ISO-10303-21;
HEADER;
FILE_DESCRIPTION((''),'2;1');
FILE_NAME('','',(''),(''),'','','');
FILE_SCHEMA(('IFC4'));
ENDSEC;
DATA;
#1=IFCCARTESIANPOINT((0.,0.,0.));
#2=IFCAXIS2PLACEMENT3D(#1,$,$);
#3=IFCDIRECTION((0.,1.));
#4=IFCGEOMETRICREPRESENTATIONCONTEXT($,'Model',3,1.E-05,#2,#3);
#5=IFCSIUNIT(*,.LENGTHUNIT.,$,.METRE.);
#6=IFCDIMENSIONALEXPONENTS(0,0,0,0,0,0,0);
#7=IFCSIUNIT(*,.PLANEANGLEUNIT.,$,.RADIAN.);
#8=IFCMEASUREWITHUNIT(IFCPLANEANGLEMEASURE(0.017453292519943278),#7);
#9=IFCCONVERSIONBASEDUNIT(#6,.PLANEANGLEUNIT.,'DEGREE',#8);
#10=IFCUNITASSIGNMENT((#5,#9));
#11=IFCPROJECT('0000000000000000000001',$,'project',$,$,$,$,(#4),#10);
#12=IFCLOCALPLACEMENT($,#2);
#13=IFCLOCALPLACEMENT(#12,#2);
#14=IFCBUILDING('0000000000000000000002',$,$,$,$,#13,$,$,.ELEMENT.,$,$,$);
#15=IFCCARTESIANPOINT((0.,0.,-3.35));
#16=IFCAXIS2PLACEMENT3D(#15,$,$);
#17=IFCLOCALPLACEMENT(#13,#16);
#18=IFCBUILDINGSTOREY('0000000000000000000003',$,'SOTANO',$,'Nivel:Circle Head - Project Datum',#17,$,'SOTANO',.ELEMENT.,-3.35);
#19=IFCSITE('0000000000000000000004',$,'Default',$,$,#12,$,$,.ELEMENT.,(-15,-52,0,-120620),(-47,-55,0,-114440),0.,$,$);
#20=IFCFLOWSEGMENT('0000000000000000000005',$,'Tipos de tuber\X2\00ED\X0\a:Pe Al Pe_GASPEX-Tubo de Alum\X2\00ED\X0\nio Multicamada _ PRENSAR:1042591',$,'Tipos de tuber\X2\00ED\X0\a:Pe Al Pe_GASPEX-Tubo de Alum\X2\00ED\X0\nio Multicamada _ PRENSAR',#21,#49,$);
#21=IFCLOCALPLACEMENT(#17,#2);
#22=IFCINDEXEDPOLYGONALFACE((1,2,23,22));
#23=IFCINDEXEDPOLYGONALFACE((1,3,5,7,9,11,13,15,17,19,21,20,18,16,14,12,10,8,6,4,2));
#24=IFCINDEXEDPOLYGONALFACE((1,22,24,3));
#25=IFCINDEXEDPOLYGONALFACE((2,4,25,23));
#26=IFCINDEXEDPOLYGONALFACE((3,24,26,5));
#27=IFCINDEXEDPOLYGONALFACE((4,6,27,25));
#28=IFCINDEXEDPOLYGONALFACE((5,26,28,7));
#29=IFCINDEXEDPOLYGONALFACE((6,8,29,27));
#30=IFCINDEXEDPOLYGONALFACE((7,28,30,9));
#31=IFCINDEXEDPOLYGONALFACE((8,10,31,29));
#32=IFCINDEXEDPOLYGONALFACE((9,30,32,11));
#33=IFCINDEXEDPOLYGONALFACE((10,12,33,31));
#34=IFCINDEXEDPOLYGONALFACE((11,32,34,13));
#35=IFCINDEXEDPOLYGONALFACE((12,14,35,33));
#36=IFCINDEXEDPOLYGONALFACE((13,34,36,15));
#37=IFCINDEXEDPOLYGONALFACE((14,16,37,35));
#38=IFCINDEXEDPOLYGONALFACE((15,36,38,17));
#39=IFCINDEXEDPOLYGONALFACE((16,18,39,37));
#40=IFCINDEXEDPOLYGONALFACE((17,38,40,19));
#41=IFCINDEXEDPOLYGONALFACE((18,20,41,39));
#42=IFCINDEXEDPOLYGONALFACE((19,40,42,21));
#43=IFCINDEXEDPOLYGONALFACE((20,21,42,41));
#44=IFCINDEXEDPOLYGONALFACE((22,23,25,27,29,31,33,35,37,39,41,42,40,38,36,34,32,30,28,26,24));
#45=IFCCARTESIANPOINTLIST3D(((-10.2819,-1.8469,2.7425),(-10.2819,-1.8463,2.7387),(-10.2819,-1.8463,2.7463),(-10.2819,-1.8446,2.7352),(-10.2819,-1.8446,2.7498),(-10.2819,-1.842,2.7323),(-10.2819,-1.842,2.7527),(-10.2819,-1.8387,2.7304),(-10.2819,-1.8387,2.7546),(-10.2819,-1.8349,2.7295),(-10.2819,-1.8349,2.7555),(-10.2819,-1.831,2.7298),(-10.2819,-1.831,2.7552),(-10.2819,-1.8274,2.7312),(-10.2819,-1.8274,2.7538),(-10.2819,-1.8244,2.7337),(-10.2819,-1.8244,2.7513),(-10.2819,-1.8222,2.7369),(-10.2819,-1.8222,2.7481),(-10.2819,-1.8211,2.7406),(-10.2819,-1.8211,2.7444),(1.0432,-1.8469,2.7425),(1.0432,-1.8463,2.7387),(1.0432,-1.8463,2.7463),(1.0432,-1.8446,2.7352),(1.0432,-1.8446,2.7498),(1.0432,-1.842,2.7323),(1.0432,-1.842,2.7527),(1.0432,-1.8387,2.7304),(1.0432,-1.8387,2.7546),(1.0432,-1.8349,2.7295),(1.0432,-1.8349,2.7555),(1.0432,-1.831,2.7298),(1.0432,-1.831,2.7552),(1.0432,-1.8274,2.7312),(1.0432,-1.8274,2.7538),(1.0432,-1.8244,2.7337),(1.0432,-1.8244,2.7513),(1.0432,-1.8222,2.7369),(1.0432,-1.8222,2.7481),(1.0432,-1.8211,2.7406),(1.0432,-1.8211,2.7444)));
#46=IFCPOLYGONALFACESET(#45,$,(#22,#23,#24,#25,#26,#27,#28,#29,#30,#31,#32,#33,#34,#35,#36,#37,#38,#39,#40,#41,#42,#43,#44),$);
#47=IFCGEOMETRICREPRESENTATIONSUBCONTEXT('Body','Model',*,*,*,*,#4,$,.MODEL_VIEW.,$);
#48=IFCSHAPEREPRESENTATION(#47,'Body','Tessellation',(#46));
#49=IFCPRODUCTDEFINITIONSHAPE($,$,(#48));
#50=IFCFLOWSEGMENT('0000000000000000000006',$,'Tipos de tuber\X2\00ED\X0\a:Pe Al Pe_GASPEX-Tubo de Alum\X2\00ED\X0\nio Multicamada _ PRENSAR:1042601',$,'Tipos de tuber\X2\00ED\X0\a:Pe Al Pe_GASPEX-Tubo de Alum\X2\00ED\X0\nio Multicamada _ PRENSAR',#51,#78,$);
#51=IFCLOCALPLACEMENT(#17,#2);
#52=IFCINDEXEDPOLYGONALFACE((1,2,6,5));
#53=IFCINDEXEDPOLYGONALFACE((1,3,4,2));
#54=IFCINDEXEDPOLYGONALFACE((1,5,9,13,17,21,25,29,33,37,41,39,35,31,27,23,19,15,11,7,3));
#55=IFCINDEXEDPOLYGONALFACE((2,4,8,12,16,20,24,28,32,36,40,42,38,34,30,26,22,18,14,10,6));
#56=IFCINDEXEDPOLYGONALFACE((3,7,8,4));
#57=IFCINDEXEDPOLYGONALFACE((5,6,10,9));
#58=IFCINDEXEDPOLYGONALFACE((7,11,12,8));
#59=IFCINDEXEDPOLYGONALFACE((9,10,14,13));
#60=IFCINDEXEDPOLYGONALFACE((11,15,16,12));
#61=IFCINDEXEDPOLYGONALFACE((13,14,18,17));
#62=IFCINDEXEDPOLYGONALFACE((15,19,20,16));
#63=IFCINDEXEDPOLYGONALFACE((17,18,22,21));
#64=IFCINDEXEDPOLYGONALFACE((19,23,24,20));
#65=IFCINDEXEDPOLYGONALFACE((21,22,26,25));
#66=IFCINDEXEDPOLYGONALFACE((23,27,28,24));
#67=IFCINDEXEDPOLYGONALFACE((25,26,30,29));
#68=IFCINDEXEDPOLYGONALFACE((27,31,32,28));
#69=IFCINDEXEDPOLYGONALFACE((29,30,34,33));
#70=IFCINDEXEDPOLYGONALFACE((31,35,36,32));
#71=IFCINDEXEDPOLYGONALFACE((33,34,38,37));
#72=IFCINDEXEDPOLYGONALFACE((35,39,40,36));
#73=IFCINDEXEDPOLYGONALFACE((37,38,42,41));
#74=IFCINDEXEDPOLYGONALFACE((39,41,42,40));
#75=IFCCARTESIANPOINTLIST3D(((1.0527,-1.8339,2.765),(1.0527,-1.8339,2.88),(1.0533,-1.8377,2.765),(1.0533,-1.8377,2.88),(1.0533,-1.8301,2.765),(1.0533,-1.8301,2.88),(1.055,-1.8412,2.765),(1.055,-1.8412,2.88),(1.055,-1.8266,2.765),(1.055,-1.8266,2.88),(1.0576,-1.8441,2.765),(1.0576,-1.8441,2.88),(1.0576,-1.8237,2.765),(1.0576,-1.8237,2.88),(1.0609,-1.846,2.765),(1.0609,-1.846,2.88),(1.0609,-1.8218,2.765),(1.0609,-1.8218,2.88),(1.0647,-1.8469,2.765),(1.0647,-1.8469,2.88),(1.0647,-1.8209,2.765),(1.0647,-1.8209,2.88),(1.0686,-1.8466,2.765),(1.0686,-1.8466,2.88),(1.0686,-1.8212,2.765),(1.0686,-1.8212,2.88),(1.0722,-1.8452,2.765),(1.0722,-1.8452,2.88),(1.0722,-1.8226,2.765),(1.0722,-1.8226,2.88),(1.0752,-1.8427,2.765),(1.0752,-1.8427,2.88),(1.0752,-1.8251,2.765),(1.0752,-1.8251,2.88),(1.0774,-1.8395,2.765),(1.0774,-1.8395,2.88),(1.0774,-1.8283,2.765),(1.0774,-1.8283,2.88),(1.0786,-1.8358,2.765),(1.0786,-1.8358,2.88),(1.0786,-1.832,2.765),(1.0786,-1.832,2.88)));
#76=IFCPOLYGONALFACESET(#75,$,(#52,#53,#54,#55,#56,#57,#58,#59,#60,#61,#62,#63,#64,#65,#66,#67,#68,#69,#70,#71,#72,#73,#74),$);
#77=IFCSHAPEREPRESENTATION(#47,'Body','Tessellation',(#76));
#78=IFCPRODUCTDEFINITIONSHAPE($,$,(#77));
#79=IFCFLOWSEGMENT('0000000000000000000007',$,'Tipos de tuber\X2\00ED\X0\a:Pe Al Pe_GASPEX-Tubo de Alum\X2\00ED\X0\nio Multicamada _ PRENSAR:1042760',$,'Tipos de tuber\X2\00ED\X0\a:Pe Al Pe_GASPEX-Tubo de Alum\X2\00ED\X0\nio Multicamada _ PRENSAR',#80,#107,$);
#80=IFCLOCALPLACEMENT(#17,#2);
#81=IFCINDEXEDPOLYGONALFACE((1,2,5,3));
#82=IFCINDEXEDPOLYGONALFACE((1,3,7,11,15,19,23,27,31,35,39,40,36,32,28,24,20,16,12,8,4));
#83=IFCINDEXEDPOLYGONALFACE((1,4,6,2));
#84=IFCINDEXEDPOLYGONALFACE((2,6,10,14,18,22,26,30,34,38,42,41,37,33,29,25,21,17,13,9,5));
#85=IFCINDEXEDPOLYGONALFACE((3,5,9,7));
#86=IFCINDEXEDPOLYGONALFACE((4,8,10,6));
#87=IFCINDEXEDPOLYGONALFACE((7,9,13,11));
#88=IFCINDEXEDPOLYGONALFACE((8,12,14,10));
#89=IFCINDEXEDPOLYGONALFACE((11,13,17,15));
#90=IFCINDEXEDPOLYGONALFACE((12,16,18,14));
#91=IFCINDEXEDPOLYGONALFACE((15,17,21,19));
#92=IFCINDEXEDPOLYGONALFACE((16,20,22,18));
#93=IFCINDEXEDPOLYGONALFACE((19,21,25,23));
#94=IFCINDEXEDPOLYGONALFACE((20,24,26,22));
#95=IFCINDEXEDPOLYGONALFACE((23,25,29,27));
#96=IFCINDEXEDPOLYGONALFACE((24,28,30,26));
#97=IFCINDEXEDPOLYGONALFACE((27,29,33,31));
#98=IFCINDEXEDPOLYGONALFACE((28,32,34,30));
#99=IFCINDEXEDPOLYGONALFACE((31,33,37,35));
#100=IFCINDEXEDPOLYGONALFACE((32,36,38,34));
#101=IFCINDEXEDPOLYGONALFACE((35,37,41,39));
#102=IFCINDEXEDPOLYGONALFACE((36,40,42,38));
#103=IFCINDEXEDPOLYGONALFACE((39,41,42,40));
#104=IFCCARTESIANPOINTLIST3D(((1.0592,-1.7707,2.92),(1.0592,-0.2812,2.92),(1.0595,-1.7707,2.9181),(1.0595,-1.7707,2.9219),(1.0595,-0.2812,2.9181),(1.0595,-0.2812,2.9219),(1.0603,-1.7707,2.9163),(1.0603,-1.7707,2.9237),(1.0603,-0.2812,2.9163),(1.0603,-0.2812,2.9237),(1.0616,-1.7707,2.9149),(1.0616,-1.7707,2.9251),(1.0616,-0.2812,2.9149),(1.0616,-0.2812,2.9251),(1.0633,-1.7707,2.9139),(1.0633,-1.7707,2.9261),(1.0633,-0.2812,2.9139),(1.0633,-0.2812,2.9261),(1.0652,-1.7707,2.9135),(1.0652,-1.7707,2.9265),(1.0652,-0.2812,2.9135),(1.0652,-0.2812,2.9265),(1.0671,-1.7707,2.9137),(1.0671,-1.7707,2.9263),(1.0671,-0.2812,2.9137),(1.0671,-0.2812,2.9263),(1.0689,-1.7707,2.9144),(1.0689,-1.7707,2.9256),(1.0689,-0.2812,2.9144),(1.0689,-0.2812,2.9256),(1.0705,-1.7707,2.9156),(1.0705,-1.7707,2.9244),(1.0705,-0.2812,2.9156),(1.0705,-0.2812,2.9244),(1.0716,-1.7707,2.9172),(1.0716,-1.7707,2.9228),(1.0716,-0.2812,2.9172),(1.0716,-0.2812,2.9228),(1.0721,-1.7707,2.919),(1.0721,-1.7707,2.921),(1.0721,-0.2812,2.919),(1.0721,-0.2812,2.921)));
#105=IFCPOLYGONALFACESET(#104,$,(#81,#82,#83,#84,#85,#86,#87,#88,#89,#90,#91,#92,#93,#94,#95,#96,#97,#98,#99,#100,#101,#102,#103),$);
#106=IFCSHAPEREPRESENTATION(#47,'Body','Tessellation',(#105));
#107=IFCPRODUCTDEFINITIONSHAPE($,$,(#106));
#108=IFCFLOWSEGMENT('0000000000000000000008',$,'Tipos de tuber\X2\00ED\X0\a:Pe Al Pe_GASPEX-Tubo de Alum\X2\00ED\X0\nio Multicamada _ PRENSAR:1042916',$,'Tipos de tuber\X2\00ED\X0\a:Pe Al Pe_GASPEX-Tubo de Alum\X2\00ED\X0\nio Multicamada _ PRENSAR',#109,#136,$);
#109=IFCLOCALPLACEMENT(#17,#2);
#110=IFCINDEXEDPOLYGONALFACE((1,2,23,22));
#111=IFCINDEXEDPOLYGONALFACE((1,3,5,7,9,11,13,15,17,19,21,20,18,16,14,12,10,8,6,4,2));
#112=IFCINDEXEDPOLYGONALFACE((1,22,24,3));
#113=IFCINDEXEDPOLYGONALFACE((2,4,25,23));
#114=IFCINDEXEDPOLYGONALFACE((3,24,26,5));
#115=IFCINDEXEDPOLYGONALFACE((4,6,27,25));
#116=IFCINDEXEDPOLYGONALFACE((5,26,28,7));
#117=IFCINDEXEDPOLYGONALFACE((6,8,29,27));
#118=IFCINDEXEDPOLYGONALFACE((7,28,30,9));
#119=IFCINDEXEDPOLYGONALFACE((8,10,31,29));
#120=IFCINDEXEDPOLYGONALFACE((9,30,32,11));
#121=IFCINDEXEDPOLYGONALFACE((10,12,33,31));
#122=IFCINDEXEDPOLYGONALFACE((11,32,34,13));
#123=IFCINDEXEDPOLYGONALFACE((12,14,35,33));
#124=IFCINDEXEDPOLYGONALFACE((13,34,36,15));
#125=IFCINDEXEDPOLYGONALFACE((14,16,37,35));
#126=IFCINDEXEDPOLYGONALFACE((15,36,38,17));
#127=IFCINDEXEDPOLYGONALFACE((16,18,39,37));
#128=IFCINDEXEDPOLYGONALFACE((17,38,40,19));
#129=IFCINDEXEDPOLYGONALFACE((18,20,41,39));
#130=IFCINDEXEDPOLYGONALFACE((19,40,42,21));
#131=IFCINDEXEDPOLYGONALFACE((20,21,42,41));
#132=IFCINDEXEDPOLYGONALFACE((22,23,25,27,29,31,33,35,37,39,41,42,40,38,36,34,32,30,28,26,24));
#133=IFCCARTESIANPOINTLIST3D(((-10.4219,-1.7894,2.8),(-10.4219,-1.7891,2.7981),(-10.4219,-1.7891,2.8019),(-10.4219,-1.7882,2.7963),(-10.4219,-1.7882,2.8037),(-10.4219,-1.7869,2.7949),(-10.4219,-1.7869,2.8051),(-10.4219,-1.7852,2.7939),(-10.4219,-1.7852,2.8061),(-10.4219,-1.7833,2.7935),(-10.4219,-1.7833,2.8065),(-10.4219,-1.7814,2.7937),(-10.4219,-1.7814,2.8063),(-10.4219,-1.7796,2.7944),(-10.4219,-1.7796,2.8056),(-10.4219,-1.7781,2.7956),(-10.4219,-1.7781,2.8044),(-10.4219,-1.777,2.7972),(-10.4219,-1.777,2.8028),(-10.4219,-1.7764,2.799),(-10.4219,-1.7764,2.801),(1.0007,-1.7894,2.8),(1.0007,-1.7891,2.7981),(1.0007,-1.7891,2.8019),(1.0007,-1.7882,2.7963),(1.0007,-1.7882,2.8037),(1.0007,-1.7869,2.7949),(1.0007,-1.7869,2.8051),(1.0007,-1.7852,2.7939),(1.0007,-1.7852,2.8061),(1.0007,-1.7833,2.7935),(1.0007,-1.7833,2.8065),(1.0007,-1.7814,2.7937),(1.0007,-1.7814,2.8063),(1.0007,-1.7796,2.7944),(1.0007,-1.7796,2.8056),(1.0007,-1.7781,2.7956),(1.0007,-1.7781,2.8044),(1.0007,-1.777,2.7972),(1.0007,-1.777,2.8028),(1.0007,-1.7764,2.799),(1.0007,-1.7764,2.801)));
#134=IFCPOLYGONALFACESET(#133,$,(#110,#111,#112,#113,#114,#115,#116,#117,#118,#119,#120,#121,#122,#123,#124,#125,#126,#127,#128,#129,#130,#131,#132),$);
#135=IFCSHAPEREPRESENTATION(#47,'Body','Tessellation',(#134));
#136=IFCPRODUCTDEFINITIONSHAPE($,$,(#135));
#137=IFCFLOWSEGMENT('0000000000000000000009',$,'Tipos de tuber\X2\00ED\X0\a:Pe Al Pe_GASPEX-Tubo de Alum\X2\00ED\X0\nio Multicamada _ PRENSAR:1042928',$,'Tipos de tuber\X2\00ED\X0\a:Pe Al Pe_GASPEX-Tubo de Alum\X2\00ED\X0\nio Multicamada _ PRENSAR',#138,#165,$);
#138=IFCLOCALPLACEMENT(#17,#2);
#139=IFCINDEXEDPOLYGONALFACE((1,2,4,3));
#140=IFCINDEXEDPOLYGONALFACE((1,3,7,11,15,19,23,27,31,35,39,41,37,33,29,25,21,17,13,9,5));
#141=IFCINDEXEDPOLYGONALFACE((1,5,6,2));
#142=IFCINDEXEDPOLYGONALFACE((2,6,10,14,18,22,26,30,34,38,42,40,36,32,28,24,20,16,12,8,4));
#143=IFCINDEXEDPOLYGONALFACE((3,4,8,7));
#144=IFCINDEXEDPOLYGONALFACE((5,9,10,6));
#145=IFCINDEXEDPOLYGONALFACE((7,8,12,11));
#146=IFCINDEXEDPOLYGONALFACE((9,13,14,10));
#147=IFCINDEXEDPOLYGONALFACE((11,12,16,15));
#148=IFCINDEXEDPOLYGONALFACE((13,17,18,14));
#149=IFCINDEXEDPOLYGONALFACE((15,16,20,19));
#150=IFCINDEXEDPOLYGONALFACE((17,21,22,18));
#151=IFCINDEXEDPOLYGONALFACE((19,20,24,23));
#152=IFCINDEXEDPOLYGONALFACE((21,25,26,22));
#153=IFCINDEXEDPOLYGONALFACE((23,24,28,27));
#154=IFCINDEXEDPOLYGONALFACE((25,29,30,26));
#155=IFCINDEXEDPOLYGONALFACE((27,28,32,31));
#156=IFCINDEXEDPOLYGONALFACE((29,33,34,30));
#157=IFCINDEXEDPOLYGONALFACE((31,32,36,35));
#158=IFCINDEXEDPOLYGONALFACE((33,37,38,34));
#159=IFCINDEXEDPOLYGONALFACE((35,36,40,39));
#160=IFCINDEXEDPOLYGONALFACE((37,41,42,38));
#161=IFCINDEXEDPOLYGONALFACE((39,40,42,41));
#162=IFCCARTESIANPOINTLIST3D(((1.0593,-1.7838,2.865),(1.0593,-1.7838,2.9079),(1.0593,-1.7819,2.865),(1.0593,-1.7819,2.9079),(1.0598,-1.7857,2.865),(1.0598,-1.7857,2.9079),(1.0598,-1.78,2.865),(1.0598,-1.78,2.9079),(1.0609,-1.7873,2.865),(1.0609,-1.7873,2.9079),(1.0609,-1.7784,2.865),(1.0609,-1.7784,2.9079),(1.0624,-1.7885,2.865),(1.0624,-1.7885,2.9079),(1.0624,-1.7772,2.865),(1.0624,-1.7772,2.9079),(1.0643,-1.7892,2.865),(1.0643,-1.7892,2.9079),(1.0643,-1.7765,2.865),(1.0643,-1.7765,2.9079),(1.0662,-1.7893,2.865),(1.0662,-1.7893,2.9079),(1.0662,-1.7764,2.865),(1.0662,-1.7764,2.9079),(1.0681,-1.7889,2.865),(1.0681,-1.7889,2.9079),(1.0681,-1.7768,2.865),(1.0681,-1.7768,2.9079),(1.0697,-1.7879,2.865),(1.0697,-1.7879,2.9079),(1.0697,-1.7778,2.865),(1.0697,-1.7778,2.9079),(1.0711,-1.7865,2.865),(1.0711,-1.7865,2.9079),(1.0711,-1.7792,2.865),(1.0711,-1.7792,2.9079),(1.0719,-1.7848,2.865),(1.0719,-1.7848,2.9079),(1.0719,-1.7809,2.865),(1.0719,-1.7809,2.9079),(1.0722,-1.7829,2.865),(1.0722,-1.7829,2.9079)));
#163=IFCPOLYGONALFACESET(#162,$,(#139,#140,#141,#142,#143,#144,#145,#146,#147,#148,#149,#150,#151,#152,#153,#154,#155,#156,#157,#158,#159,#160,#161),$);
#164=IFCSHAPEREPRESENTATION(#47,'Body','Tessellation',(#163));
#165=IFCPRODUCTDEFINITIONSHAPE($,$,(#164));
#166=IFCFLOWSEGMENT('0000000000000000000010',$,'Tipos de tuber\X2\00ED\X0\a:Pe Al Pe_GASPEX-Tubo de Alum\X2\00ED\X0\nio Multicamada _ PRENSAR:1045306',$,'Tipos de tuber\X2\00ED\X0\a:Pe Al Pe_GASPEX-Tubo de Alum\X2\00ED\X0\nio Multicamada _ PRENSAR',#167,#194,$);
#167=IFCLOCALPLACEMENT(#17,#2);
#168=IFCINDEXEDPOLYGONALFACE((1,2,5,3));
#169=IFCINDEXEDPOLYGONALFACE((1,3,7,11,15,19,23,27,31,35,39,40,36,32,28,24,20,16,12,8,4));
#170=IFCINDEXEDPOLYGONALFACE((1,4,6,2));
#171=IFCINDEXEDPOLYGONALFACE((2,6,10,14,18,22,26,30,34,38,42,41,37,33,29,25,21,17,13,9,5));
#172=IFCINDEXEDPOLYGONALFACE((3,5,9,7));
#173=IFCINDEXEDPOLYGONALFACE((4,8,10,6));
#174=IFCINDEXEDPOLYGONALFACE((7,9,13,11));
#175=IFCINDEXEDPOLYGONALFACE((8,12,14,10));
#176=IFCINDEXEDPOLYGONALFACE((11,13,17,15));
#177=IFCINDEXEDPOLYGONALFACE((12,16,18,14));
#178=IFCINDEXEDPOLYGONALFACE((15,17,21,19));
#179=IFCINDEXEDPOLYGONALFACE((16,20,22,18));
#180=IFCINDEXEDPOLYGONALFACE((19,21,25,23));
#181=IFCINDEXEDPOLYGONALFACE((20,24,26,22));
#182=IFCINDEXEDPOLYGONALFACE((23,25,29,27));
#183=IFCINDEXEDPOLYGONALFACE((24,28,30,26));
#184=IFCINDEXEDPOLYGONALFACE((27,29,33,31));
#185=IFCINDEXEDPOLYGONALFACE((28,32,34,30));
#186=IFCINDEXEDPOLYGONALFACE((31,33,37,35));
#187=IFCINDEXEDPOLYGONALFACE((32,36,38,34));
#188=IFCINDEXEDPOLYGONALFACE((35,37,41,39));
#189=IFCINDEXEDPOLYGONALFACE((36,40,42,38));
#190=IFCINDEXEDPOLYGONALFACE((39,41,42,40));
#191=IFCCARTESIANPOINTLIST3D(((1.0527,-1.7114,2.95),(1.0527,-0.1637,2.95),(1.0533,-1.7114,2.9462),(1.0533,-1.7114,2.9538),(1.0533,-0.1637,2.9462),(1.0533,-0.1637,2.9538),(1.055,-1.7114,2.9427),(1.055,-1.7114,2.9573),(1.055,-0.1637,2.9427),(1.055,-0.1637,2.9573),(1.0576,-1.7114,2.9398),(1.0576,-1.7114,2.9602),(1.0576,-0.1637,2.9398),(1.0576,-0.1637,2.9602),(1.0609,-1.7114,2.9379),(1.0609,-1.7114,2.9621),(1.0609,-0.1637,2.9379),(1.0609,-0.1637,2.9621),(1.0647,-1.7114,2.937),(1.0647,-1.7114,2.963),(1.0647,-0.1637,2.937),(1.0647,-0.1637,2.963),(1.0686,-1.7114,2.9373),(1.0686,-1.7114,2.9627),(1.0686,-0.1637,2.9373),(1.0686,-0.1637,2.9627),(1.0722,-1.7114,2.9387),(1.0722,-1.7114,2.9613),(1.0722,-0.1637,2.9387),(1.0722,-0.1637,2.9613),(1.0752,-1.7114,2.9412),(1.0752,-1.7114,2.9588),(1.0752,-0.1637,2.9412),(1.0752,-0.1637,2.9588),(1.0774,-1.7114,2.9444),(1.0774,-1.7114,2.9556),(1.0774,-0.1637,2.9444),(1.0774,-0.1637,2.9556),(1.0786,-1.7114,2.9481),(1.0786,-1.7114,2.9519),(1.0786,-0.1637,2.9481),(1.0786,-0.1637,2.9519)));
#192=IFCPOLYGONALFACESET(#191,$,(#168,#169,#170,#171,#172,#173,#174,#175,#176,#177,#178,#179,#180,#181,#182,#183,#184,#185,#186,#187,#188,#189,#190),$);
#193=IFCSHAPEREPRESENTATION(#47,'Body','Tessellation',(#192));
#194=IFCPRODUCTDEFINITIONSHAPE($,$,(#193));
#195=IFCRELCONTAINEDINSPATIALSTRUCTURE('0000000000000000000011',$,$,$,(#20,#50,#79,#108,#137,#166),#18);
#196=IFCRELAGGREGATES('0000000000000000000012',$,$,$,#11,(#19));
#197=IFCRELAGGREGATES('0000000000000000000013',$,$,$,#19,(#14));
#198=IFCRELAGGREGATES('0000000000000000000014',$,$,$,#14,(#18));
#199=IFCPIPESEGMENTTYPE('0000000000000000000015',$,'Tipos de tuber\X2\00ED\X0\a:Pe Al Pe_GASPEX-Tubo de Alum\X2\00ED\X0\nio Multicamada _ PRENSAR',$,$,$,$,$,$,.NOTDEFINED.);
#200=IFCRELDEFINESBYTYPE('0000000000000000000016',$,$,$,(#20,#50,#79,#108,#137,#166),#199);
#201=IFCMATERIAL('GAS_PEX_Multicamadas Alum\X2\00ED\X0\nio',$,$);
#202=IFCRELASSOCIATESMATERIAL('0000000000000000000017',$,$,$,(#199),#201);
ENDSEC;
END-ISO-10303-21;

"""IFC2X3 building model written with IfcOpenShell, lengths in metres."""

from ifc_helpers import new_model, entity, si_unit, converted_unit, direction, frame, frame_2d, origin, origin_2d_with_axis, place, context, subcontext, project, spatial, circle, extrude, material, type_object, element, save


model = new_model("IFC2X3")

# Units and contexts
model_context = context("Model", 3, precision=1e-05, world=origin(), true_north=direction((0.0, 1.0)))
body_context = subcontext(model_context, "Body", "Model", "MODEL_VIEW")
ifc_project = project(units=[si_unit("LENGTHUNIT", "METRE"), converted_unit("PLANEANGLEUNIT", "DEGREE", entity("IfcPlaneAngleMeasure", 0.017453292519943278), si_unit("PLANEANGLEUNIT", "RADIAN"), dimensions=[0, 0, 0, 0, 0, 0, 0])], contexts=[model_context])

# Site, building, storey
site_placement = place(None, origin())
site = spatial("IfcSite", under=ifc_project, at=site_placement, Name="Default", CompositionType="ELEMENT", RefLatitude=(-15, -52, 0, -120620), RefLongitude=(-47, -55, 0, -114440), RefElevation=0.0)
building_placement = place(site_placement, origin())
building = spatial("IfcBuilding", under=site, at=building_placement, CompositionType="ELEMENT")
storey_placement = place(building_placement, frame((0.0, 0.0, -3.35)))
storey = spatial("IfcBuildingStorey", under=building, at=storey_placement, Name="SOTANO", ObjectType="Nivel:Circle Head - Project Datum", LongName="SOTANO", CompositionType="ELEMENT", Elevation=-3.35)

# Flow segments
ifc_material = material(Name="GAS_PEX_Multicamadas Alumínio")
pipe_segment_type_1 = type_object("IfcPipeSegmentType", Name="Tipos de tubería:Pe Al Pe_GASPEX-Tubo de Alumínio Multicamada _ PRENSAR", PredefinedType="NOTDEFINED", material=ifc_material)
flow_segment_1_placement = place(storey_placement, origin())
element("IfcFlowSegment", 1, at=flow_segment_1_placement, inside=storey, type_object=pipe_segment_type_1, Name="Tipos de tubería:Pe Al Pe_GASPEX-Tubo de Alumínio Multicamada _ PRENSAR:1042591", ObjectType="Tipos de tubería:Pe Al Pe_GASPEX-Tubo de Alumínio Multicamada _ PRENSAR", context=body_context, shape_type="SweptSolid", body=[
    extrude(circle(Radius=0.013, at=origin_2d_with_axis()), frame((-10.2819, -1.8339, 2.7425), z_axis=(1.0, 0.0, 0.0), x_axis=(0.0, -1.0, 0.0)), (0.0, 0.0, 1.0), 11.3251),
])
flow_segment_2_placement = place(storey_placement, origin())
element("IfcFlowSegment", 2, at=flow_segment_2_placement, inside=storey, type_object=pipe_segment_type_1, Name="Tipos de tubería:Pe Al Pe_GASPEX-Tubo de Alumínio Multicamada _ PRENSAR:1042601", ObjectType="Tipos de tubería:Pe Al Pe_GASPEX-Tubo de Alumínio Multicamada _ PRENSAR", context=body_context, shape_type="SweptSolid", body=[
    extrude(circle(Radius=0.013, at=frame_2d((0.0, 0.0), x_axis=(1.0, 0.0))), frame((1.0657, -1.8339, 2.765), z_axis=(0.0, 0.0, 1.0), x_axis=(-1.0, 0.0, 0.0)), (0.0, 0.0, 1.0), 0.115),
])
flow_segment_3_placement = place(storey_placement, origin())
element("IfcFlowSegment", 3, at=flow_segment_3_placement, inside=storey, type_object=pipe_segment_type_1, Name="Tipos de tubería:Pe Al Pe_GASPEX-Tubo de Alumínio Multicamada _ PRENSAR:1042760", ObjectType="Tipos de tubería:Pe Al Pe_GASPEX-Tubo de Alumínio Multicamada _ PRENSAR", context=body_context, shape_type="SweptSolid", body=[
    extrude(circle(Radius=0.0065, at=frame_2d((0.0, 0.0), x_axis=(1.0, 0.0))), frame((1.0657, -1.7707, 2.92), z_axis=(0.0, 1.0, 0.0), x_axis=(-1.0, 0.0, 0.0)), (0.0, 0.0, 1.0), 1.4895),
])
flow_segment_4_placement = place(storey_placement, origin())
element("IfcFlowSegment", 4, at=flow_segment_4_placement, inside=storey, type_object=pipe_segment_type_1, Name="Tipos de tubería:Pe Al Pe_GASPEX-Tubo de Alumínio Multicamada _ PRENSAR:1042916", ObjectType="Tipos de tubería:Pe Al Pe_GASPEX-Tubo de Alumínio Multicamada _ PRENSAR", context=body_context, shape_type="SweptSolid", body=[
    extrude(circle(Radius=0.0065, at=origin_2d_with_axis()), frame((-10.4219, -1.7829, 2.8), z_axis=(1.0, 0.0, 0.0), x_axis=(0.0, -1.0, 0.0)), (0.0, 0.0, 1.0), 11.4226),
])
flow_segment_5_placement = place(storey_placement, origin())
element("IfcFlowSegment", 5, at=flow_segment_5_placement, inside=storey, type_object=pipe_segment_type_1, Name="Tipos de tubería:Pe Al Pe_GASPEX-Tubo de Alumínio Multicamada _ PRENSAR:1042928", ObjectType="Tipos de tubería:Pe Al Pe_GASPEX-Tubo de Alumínio Multicamada _ PRENSAR", context=body_context, shape_type="SweptSolid", body=[
    extrude(circle(Radius=0.0065, at=frame_2d((0.0, 0.0), x_axis=(1.0, 0.0))), frame((1.0657, -1.7829, 2.865)), (0.0, 0.0, 1.0), 0.0429),
])
flow_segment_6_placement = place(storey_placement, origin())
element("IfcFlowSegment", 6, at=flow_segment_6_placement, inside=storey, type_object=pipe_segment_type_1, Name="Tipos de tubería:Pe Al Pe_GASPEX-Tubo de Alumínio Multicamada _ PRENSAR:1045306", ObjectType="Tipos de tubería:Pe Al Pe_GASPEX-Tubo de Alumínio Multicamada _ PRENSAR", context=body_context, shape_type="SweptSolid", body=[
    extrude(circle(Radius=0.013, at=frame_2d((0.0, 0.0), x_axis=(1.0, 0.0))), frame((1.0657, -1.7114, 2.95), z_axis=(0.0, 1.0, 0.0), x_axis=(-1.0, 0.0, 0.0)), (0.0, 0.0, 1.0), 1.5477),
])

save(model, "model.ifc")
